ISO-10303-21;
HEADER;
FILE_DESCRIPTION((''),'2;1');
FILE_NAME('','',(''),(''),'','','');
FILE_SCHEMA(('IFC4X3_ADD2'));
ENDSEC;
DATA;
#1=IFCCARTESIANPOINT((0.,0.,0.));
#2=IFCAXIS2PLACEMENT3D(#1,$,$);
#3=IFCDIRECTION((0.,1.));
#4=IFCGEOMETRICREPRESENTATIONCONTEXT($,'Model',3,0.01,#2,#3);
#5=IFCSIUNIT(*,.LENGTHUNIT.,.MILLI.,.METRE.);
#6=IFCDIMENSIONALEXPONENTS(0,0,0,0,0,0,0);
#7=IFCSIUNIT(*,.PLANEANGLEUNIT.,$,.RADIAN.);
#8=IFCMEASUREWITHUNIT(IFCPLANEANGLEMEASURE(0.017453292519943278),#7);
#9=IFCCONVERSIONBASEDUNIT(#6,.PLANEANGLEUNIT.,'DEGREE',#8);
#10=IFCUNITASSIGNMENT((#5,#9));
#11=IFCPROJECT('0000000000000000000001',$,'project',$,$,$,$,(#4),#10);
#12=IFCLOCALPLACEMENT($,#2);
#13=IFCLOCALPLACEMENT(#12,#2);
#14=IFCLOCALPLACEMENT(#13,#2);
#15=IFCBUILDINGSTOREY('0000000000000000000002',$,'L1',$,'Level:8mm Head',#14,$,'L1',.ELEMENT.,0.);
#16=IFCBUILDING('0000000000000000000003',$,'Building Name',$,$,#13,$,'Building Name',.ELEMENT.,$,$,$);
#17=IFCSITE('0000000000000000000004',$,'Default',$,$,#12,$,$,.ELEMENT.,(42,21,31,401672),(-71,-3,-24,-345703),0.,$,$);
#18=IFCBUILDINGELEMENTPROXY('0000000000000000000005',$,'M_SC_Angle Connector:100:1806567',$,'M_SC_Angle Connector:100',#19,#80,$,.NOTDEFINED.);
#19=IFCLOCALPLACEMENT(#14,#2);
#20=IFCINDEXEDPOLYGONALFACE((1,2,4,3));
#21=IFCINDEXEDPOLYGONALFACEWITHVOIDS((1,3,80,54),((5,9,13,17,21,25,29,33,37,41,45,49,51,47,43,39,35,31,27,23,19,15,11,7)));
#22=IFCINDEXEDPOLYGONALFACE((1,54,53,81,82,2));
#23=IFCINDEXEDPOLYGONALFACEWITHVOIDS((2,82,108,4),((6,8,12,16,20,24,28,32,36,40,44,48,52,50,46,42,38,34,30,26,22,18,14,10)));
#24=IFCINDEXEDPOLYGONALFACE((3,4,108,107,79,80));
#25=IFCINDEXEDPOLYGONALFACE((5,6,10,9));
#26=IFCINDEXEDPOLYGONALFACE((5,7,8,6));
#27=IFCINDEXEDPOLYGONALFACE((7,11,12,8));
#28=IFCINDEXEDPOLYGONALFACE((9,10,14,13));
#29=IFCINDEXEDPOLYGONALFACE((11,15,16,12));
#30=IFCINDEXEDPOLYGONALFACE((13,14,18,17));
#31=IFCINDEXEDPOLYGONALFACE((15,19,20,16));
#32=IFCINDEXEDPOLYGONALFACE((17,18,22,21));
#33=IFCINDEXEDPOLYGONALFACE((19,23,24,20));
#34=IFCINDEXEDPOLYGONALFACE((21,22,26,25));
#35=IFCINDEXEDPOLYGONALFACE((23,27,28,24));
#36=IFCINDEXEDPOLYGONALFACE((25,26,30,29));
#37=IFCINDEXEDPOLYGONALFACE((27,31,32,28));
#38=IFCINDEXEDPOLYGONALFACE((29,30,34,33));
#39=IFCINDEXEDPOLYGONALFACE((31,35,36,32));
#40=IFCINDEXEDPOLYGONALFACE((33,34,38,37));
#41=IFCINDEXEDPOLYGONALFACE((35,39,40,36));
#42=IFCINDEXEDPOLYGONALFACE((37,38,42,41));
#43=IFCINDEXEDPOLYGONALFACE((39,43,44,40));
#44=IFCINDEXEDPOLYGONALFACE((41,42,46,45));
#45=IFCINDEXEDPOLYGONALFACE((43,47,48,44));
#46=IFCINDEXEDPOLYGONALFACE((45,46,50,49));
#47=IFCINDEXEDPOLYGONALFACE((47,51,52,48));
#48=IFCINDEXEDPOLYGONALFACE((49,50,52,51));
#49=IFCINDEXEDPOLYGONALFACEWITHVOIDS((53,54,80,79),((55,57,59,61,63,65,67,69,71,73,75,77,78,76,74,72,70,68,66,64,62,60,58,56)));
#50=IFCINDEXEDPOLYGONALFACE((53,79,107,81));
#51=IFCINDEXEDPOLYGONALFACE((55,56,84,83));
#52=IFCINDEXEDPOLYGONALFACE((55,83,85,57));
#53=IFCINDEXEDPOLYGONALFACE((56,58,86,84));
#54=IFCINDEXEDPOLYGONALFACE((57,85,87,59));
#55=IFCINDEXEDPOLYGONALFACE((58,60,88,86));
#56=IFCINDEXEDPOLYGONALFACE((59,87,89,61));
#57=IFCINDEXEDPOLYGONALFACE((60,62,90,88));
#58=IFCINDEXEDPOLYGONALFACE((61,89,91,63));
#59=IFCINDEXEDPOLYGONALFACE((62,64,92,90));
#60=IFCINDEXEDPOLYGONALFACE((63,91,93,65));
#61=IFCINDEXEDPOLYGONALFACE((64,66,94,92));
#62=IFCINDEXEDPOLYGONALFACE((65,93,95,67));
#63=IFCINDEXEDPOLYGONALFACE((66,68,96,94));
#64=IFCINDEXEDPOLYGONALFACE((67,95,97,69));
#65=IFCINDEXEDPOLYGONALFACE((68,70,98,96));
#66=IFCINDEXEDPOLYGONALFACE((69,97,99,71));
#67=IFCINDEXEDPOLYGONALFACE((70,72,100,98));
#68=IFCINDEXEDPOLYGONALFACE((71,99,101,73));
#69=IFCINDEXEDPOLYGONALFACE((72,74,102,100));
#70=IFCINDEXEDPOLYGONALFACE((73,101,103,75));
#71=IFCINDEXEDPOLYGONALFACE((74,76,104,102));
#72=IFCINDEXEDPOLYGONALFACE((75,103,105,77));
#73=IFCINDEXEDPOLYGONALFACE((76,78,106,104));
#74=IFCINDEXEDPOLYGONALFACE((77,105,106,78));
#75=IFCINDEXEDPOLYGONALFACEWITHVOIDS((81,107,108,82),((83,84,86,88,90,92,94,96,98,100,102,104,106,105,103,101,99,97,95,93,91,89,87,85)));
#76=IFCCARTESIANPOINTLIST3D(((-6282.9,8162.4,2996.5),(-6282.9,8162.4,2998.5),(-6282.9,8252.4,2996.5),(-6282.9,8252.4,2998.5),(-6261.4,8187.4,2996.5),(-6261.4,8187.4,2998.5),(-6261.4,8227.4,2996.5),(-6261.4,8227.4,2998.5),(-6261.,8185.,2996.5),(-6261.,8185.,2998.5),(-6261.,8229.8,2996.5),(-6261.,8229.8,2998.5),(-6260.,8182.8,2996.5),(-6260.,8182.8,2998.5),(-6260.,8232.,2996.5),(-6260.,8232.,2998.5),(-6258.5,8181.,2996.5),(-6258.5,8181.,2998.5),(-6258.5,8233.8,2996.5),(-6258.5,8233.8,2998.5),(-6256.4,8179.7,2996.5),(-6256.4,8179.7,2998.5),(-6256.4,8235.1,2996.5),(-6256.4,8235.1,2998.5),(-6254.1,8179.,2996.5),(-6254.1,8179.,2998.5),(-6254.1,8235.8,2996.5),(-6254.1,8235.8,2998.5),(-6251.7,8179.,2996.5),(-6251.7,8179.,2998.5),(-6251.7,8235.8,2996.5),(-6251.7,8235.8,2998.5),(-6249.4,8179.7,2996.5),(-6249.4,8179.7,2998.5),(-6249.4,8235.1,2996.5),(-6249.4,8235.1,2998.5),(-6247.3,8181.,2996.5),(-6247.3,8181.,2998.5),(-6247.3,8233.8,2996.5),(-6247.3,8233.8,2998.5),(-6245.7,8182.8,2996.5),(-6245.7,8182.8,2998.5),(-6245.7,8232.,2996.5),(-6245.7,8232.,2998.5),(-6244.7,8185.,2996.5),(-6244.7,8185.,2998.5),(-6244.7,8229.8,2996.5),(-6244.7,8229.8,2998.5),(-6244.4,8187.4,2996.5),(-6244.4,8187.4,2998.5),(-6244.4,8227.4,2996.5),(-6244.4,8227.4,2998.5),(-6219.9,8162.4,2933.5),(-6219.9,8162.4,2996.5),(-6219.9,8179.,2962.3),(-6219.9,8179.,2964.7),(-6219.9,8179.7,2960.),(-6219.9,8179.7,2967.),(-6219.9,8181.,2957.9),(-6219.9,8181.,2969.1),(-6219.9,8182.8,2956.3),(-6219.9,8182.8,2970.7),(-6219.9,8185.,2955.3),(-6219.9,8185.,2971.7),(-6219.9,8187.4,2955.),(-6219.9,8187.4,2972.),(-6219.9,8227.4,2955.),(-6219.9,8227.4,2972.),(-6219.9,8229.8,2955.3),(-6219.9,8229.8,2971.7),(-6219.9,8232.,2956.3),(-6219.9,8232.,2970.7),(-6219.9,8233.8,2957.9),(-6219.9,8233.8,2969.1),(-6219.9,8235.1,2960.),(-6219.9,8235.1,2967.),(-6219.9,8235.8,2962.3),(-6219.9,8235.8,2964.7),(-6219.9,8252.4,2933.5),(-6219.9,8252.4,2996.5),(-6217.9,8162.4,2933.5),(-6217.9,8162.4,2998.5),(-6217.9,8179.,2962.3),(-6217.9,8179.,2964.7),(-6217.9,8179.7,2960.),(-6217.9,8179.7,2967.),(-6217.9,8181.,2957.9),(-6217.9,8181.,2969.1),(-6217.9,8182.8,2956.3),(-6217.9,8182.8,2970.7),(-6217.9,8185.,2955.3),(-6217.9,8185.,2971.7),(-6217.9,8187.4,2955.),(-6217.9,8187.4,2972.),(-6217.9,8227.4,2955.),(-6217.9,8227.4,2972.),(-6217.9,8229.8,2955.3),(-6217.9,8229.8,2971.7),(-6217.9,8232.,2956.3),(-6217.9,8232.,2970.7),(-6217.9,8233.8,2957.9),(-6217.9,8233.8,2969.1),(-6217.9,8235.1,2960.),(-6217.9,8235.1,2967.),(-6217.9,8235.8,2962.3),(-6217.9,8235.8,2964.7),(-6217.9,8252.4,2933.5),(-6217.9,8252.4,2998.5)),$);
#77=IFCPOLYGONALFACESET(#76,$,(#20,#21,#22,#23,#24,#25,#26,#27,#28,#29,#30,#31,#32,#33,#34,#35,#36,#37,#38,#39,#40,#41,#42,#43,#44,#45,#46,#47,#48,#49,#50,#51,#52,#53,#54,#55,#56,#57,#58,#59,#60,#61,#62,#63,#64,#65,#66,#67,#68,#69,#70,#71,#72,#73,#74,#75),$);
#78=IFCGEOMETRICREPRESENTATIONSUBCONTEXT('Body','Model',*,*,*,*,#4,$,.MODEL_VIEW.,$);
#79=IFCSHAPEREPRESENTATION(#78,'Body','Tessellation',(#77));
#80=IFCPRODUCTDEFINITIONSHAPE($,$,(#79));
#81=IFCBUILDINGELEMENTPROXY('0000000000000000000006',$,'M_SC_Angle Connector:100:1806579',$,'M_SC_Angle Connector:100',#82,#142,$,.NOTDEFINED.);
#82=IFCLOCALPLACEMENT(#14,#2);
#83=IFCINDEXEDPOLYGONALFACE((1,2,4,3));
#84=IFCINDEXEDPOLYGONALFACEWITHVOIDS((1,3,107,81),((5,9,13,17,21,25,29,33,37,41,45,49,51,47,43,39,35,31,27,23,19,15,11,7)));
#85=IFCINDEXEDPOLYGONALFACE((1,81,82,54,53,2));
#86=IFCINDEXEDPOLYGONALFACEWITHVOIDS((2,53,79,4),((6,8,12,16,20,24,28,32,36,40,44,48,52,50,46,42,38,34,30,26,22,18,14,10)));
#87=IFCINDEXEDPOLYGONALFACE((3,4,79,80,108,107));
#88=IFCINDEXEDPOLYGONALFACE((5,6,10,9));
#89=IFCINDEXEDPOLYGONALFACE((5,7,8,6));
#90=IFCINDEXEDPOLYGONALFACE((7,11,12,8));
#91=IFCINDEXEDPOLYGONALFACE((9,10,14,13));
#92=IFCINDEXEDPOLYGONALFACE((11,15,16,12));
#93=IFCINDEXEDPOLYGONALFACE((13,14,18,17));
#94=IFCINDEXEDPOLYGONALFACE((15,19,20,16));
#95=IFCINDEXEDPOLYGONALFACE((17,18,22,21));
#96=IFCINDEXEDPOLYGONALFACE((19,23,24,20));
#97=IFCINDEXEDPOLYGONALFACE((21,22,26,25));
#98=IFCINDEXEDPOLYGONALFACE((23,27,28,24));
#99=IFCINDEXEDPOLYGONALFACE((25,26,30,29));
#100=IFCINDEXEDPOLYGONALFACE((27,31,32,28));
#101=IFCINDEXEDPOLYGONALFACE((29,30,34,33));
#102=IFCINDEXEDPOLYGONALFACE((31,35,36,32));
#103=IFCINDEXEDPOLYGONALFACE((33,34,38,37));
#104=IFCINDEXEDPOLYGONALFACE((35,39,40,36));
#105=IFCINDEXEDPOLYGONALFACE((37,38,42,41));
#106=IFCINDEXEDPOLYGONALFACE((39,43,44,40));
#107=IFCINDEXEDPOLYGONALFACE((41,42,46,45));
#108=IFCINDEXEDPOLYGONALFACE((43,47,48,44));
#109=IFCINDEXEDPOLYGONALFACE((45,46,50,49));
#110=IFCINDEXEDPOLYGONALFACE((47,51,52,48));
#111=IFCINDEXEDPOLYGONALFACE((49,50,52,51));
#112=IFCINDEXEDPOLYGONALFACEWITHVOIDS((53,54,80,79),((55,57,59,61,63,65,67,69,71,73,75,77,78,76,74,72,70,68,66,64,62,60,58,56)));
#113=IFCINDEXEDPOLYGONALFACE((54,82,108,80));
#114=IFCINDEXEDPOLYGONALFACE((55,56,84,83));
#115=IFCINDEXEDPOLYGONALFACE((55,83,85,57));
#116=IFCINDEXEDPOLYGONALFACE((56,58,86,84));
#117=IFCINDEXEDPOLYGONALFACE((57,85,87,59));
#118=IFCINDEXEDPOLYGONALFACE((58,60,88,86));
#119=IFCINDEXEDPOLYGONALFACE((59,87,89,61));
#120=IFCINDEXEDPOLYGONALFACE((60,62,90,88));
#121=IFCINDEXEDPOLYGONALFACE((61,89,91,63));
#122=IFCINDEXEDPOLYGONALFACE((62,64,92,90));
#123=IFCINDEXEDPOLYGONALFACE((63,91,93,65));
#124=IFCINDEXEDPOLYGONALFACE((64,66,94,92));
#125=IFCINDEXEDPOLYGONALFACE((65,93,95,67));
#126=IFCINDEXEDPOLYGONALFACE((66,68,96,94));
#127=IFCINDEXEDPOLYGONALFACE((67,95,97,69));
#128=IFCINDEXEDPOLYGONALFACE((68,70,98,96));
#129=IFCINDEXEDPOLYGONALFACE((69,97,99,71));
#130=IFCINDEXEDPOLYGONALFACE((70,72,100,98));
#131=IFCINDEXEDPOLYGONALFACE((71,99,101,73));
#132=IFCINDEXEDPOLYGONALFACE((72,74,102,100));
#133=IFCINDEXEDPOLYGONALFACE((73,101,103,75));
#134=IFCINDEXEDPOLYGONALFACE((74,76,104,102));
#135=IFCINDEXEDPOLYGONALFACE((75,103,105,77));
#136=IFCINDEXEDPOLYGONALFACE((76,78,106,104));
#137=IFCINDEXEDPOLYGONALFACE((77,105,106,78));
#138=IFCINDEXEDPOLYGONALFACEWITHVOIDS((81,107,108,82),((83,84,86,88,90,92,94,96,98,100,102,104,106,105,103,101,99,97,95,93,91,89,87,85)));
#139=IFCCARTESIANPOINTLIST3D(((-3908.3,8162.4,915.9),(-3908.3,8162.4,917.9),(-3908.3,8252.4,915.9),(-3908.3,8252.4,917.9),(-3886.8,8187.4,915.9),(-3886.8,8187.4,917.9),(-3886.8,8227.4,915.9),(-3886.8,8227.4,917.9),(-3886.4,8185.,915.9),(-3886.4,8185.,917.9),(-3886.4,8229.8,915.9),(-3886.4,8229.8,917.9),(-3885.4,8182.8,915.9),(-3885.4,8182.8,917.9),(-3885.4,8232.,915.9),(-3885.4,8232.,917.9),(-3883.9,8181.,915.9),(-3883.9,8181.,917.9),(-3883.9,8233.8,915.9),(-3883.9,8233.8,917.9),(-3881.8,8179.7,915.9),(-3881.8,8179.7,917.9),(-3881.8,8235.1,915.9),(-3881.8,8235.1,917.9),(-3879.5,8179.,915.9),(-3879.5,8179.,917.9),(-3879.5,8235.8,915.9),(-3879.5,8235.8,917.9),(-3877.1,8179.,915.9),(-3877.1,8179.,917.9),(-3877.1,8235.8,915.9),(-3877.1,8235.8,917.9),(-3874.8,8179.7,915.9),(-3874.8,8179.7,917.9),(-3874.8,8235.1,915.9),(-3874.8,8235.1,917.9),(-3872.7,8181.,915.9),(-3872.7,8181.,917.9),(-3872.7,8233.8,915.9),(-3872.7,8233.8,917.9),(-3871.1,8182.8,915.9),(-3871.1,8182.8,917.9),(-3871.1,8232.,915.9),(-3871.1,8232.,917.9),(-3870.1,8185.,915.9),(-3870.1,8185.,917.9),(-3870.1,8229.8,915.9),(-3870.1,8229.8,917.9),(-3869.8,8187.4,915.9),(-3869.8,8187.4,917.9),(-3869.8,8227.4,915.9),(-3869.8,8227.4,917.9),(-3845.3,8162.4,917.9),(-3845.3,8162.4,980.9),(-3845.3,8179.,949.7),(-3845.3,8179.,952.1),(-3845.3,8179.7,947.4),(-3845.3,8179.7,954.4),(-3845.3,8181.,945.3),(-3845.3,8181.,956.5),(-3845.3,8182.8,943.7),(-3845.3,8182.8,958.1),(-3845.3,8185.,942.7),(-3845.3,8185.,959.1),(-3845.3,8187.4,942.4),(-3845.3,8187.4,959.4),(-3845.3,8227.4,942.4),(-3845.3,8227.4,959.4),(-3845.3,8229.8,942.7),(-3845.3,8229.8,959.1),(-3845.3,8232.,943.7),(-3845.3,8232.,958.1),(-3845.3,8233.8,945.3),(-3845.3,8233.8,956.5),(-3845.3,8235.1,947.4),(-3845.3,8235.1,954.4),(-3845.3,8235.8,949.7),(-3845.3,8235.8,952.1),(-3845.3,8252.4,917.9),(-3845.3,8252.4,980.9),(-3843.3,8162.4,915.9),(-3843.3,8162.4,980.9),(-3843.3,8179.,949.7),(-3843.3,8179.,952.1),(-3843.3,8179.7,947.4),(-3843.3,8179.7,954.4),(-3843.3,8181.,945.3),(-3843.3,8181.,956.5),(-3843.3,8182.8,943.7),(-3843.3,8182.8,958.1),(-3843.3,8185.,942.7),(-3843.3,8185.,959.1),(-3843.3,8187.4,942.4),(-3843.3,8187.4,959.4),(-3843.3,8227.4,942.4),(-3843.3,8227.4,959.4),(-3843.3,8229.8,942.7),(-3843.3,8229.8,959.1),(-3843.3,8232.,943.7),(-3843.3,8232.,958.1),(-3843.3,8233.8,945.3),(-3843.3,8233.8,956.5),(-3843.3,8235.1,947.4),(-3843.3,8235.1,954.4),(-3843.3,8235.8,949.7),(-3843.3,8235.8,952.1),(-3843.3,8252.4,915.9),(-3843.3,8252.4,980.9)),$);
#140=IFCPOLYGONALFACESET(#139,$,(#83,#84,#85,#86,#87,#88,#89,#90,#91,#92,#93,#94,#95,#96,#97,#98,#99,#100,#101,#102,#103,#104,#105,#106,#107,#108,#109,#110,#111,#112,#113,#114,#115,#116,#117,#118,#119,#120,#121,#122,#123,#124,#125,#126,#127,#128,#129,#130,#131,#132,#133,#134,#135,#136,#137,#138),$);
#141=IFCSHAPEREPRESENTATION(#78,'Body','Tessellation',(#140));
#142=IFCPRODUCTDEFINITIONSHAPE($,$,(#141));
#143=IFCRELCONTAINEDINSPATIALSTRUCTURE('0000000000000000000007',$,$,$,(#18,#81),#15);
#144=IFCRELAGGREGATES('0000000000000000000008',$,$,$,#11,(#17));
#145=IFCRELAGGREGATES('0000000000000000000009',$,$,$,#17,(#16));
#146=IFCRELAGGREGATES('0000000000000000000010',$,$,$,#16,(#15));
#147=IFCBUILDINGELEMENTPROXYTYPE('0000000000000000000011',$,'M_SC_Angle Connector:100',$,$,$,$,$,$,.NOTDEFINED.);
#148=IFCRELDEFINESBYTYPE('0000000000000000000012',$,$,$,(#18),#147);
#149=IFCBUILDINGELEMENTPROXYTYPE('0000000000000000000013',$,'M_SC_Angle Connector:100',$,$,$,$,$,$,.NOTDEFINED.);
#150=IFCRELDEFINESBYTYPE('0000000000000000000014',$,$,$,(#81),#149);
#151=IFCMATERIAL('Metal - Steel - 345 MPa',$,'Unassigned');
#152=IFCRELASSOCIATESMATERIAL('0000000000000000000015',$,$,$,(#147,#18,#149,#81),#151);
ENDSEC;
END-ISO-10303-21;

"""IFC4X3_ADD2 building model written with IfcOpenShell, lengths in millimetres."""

from ifc_helpers import new_model, entity, si_unit, converted_unit, direction, frame, frame_2d, origin, place, context, subcontext, project, spatial, polyline, circle_curve, parameter, trimmed, segment, composite_curve, outline, extrude, source, transform, mapped, material, type_object, type_shapes, element, save


model = new_model("IFC4X3_ADD2")

# Units and contexts
model_context = context("Model", 3, precision=0.01, world=origin(), true_north=direction((0.0, 1.0)))
body_context = subcontext(model_context, "Body", "Model", "MODEL_VIEW")
ifc_project = project(units=[si_unit("LENGTHUNIT", "METRE", prefix="MILLI"), converted_unit("PLANEANGLEUNIT", "DEGREE", entity("IfcPlaneAngleMeasure", 0.017453292519943278), si_unit("PLANEANGLEUNIT", "RADIAN"), dimensions=[0, 0, 0, 0, 0, 0, 0])], contexts=[model_context])

# Site, building, storey
site_placement = place(None, origin())
site = spatial("IfcSite", under=ifc_project, at=site_placement, Name="Default", CompositionType="ELEMENT", RefLatitude=(42, 21, 31, 401672), RefLongitude=(-71, -3, -24, -345703), RefElevation=0.0)
building_placement = place(site_placement, origin())
building = spatial("IfcBuilding", under=site, at=building_placement, Name="Building Name", LongName="Building Name", CompositionType="ELEMENT")
storey_placement = place(building_placement, origin())
storey = spatial("IfcBuildingStorey", under=building, at=storey_placement, Name="L1", ObjectType="Level:8mm Head", LongName="L1", CompositionType="ELEMENT", Elevation=0.0)

# Building element proxies, openings
ifc_material_1 = material(Name="Metal - Steel - 345 MPa", Category="Unassigned")
building_element_proxy_type_1 = type_object("IfcBuildingElementProxyType", Name="M_SC_Angle Connector:100", PredefinedType="NOTDEFINED", material=ifc_material_1)
shared_shape_1 = source(origin(), body_context, "Body", "SweptSolid", [
    extrude(outline(polyline([(-42.7, -22.3), (22.3, -22.3), (22.3, 42.7), (20.3, 42.7), (20.3, -20.3), (-42.7, -20.3), (-42.7, -22.3)])), frame((22.3, -45.0, 22.3), z_axis=(0.0, 1.0, 0.0), x_axis=(-1.0, 0.0, 0.0)), (0.0, 0.0, 1.0), 90.0),
])
type_shapes(building_element_proxy_type_1, [shared_shape_1])
proxy_1_placement = place(storey_placement, frame((-6217.9, 8207.4, 2998.5), z_axis=(0.0, 0.0, -1.0), x_axis=(-1.0, 0.0, 0.0)))
proxy_1 = element("IfcBuildingElementProxy", 1, at=proxy_1_placement, inside=storey, type_object=building_element_proxy_type_1, material=ifc_material_1, Name="M_SC_Angle Connector:100:1806567", ObjectType="M_SC_Angle Connector:100", PredefinedType="NOTDEFINED", context=body_context, shape_type="MappedRepresentation", body=[
    mapped(shared_shape_1, transform((0.0, 0.0, 0.0), scale=1.0)),
])
opening_1_placement = place(storey_placement, frame((-6217.9, 8207.4, 2998.5)))
element("IfcOpeningElement", 2, at=opening_1_placement, cuts=proxy_1, PredefinedType="OPENING", context=body_context, shape_type="SweptSolid", body=[
    extrude(outline(composite_curve([segment(trimmed(circle_curve(frame_2d((0.0, -20.0), x_axis=(1.0, 0.0)), 8.5), [parameter(180.0)], [parameter(0.0)], True, "PARAMETER"), True, "CONTINUOUS"), segment(polyline([(8.5, -20.0), (8.5, 20.0)]), True, "CONTINUOUS"), segment(trimmed(circle_curve(frame_2d((0.0, 20.0), x_axis=(1.0, 0.0)), 8.5), [parameter(0.0)], [parameter(180.0)], True, "PARAMETER"), True, "CONTINUOUS"), segment(polyline([(-8.5, 20.0), (-8.5, -20.0)]), True, "CONTINUOUS")], self_intersect=False)), frame((-2.0, 0.0, -35.0), z_axis=(1.0, 0.0, 0.0), x_axis=(0.0, 0.0, -1.0)), (0.0, 0.0, 1.0), 2.0),
])
opening_2_placement = place(storey_placement, frame((-6217.9, 8207.4, 2998.5)))
element("IfcOpeningElement", 3, at=opening_2_placement, cuts=proxy_1, PredefinedType="OPENING", context=body_context, shape_type="SweptSolid", body=[
    extrude(outline(composite_curve([segment(trimmed(circle_curve(frame_2d((0.0, 20.0), x_axis=(1.0, 0.0)), 8.5), [parameter(0.0)], [parameter(180.0)], True, "PARAMETER"), True, "CONTINUOUS"), segment(polyline([(-8.5, 20.0), (-8.5, -20.0)]), True, "CONTINUOUS"), segment(trimmed(circle_curve(frame_2d((0.0, -20.0), x_axis=(1.0, 0.0)), 8.5), [parameter(180.0)], [parameter(0.0)], True, "PARAMETER"), True, "CONTINUOUS"), segment(polyline([(8.5, -20.0), (8.5, 20.0)]), True, "CONTINUOUS")], self_intersect=False)), frame((-35.0, 0.0, -2.0), z_axis=(0.0, 0.0, 1.0), x_axis=(-1.0, 0.0, 0.0)), (0.0, 0.0, 1.0), 2.0),
])
building_element_proxy_type_2 = type_object("IfcBuildingElementProxyType", Name="M_SC_Angle Connector:100", PredefinedType="NOTDEFINED", material=ifc_material_1)
shared_shape_2 = source(origin(), body_context, "Body", "SweptSolid", [
    extrude(outline(polyline([(-42.7, -22.3), (22.3, -22.3), (22.3, 42.7), (20.3, 42.7), (20.3, -20.3), (-42.7, -20.3), (-42.7, -22.3)])), frame((22.3, -45.0, 22.3), z_axis=(0.0, 1.0, 0.0), x_axis=(-1.0, 0.0, 0.0)), (0.0, 0.0, 1.0), 90.0),
])
type_shapes(building_element_proxy_type_2, [shared_shape_2])
proxy_2_placement = place(storey_placement, frame((-3843.3, 8207.4, 915.9), z_axis=(0.0, 0.0, 1.0), x_axis=(-1.0, 0.0, 0.0)))
proxy_2 = element("IfcBuildingElementProxy", 4, at=proxy_2_placement, inside=storey, type_object=building_element_proxy_type_2, material=ifc_material_1, Name="M_SC_Angle Connector:100:1806579", ObjectType="M_SC_Angle Connector:100", PredefinedType="NOTDEFINED", context=body_context, shape_type="MappedRepresentation", body=[
    mapped(shared_shape_2, transform((0.0, 0.0, 0.0), scale=1.0)),
])
opening_3_placement = place(storey_placement, frame((-3843.3, 8207.4, 915.9)))
element("IfcOpeningElement", 5, at=opening_3_placement, cuts=proxy_2, PredefinedType="OPENING", context=body_context, shape_type="SweptSolid", body=[
    extrude(outline(composite_curve([segment(polyline([(-20.0, -8.5), (20.0, -8.5)]), True, "CONTINUOUS"), segment(trimmed(circle_curve(frame_2d((20.0, 0.0), x_axis=(0.0, 1.0)), 8.5), [parameter(180.0)], [parameter(360.0)], True, "PARAMETER"), True, "CONTINUOUS"), segment(polyline([(20.0, 8.5), (-20.0, 8.5)]), True, "CONTINUOUS"), segment(trimmed(circle_curve(frame_2d((-20.0, 0.0), x_axis=(0.0, 1.0)), 8.5), [parameter(360.0)], [parameter(180.0)], True, "PARAMETER"), True, "CONTINUOUS")], self_intersect=False)), frame((-2.0, 0.0, 35.0), z_axis=(1.0, 0.0, 0.0), x_axis=(0.0, 1.0, 0.0)), (0.0, 0.0, 1.0), 2.0),
])
opening_4_placement = place(storey_placement, frame((-3843.3, 8207.4, 915.9)))
element("IfcOpeningElement", 6, at=opening_4_placement, cuts=proxy_2, PredefinedType="OPENING", context=body_context, shape_type="SweptSolid", body=[
    extrude(outline(composite_curve([segment(polyline([(-20.0, -8.5), (20.0, -8.5)]), True, "CONTINUOUS"), segment(trimmed(circle_curve(frame_2d((20.0, 0.0), x_axis=(0.0, -1.0)), 8.5), [parameter(360.0)], [parameter(180.0)], True, "PARAMETER"), True, "CONTINUOUS"), segment(polyline([(20.0, 8.5), (-20.0, 8.5)]), True, "CONTINUOUS"), segment(trimmed(circle_curve(frame_2d((-20.0, 0.0), x_axis=(0.0, -1.0)), 8.5), [parameter(180.0)], [parameter(360.0)], True, "PARAMETER"), True, "CONTINUOUS")], self_intersect=False)), frame((-35.0, 0.0, 2.0), z_axis=(0.0, 0.0, -1.0), x_axis=(0.0, 1.0, 0.0)), (0.0, 0.0, 1.0), 2.0),
])

save(model, "model.ifc")
